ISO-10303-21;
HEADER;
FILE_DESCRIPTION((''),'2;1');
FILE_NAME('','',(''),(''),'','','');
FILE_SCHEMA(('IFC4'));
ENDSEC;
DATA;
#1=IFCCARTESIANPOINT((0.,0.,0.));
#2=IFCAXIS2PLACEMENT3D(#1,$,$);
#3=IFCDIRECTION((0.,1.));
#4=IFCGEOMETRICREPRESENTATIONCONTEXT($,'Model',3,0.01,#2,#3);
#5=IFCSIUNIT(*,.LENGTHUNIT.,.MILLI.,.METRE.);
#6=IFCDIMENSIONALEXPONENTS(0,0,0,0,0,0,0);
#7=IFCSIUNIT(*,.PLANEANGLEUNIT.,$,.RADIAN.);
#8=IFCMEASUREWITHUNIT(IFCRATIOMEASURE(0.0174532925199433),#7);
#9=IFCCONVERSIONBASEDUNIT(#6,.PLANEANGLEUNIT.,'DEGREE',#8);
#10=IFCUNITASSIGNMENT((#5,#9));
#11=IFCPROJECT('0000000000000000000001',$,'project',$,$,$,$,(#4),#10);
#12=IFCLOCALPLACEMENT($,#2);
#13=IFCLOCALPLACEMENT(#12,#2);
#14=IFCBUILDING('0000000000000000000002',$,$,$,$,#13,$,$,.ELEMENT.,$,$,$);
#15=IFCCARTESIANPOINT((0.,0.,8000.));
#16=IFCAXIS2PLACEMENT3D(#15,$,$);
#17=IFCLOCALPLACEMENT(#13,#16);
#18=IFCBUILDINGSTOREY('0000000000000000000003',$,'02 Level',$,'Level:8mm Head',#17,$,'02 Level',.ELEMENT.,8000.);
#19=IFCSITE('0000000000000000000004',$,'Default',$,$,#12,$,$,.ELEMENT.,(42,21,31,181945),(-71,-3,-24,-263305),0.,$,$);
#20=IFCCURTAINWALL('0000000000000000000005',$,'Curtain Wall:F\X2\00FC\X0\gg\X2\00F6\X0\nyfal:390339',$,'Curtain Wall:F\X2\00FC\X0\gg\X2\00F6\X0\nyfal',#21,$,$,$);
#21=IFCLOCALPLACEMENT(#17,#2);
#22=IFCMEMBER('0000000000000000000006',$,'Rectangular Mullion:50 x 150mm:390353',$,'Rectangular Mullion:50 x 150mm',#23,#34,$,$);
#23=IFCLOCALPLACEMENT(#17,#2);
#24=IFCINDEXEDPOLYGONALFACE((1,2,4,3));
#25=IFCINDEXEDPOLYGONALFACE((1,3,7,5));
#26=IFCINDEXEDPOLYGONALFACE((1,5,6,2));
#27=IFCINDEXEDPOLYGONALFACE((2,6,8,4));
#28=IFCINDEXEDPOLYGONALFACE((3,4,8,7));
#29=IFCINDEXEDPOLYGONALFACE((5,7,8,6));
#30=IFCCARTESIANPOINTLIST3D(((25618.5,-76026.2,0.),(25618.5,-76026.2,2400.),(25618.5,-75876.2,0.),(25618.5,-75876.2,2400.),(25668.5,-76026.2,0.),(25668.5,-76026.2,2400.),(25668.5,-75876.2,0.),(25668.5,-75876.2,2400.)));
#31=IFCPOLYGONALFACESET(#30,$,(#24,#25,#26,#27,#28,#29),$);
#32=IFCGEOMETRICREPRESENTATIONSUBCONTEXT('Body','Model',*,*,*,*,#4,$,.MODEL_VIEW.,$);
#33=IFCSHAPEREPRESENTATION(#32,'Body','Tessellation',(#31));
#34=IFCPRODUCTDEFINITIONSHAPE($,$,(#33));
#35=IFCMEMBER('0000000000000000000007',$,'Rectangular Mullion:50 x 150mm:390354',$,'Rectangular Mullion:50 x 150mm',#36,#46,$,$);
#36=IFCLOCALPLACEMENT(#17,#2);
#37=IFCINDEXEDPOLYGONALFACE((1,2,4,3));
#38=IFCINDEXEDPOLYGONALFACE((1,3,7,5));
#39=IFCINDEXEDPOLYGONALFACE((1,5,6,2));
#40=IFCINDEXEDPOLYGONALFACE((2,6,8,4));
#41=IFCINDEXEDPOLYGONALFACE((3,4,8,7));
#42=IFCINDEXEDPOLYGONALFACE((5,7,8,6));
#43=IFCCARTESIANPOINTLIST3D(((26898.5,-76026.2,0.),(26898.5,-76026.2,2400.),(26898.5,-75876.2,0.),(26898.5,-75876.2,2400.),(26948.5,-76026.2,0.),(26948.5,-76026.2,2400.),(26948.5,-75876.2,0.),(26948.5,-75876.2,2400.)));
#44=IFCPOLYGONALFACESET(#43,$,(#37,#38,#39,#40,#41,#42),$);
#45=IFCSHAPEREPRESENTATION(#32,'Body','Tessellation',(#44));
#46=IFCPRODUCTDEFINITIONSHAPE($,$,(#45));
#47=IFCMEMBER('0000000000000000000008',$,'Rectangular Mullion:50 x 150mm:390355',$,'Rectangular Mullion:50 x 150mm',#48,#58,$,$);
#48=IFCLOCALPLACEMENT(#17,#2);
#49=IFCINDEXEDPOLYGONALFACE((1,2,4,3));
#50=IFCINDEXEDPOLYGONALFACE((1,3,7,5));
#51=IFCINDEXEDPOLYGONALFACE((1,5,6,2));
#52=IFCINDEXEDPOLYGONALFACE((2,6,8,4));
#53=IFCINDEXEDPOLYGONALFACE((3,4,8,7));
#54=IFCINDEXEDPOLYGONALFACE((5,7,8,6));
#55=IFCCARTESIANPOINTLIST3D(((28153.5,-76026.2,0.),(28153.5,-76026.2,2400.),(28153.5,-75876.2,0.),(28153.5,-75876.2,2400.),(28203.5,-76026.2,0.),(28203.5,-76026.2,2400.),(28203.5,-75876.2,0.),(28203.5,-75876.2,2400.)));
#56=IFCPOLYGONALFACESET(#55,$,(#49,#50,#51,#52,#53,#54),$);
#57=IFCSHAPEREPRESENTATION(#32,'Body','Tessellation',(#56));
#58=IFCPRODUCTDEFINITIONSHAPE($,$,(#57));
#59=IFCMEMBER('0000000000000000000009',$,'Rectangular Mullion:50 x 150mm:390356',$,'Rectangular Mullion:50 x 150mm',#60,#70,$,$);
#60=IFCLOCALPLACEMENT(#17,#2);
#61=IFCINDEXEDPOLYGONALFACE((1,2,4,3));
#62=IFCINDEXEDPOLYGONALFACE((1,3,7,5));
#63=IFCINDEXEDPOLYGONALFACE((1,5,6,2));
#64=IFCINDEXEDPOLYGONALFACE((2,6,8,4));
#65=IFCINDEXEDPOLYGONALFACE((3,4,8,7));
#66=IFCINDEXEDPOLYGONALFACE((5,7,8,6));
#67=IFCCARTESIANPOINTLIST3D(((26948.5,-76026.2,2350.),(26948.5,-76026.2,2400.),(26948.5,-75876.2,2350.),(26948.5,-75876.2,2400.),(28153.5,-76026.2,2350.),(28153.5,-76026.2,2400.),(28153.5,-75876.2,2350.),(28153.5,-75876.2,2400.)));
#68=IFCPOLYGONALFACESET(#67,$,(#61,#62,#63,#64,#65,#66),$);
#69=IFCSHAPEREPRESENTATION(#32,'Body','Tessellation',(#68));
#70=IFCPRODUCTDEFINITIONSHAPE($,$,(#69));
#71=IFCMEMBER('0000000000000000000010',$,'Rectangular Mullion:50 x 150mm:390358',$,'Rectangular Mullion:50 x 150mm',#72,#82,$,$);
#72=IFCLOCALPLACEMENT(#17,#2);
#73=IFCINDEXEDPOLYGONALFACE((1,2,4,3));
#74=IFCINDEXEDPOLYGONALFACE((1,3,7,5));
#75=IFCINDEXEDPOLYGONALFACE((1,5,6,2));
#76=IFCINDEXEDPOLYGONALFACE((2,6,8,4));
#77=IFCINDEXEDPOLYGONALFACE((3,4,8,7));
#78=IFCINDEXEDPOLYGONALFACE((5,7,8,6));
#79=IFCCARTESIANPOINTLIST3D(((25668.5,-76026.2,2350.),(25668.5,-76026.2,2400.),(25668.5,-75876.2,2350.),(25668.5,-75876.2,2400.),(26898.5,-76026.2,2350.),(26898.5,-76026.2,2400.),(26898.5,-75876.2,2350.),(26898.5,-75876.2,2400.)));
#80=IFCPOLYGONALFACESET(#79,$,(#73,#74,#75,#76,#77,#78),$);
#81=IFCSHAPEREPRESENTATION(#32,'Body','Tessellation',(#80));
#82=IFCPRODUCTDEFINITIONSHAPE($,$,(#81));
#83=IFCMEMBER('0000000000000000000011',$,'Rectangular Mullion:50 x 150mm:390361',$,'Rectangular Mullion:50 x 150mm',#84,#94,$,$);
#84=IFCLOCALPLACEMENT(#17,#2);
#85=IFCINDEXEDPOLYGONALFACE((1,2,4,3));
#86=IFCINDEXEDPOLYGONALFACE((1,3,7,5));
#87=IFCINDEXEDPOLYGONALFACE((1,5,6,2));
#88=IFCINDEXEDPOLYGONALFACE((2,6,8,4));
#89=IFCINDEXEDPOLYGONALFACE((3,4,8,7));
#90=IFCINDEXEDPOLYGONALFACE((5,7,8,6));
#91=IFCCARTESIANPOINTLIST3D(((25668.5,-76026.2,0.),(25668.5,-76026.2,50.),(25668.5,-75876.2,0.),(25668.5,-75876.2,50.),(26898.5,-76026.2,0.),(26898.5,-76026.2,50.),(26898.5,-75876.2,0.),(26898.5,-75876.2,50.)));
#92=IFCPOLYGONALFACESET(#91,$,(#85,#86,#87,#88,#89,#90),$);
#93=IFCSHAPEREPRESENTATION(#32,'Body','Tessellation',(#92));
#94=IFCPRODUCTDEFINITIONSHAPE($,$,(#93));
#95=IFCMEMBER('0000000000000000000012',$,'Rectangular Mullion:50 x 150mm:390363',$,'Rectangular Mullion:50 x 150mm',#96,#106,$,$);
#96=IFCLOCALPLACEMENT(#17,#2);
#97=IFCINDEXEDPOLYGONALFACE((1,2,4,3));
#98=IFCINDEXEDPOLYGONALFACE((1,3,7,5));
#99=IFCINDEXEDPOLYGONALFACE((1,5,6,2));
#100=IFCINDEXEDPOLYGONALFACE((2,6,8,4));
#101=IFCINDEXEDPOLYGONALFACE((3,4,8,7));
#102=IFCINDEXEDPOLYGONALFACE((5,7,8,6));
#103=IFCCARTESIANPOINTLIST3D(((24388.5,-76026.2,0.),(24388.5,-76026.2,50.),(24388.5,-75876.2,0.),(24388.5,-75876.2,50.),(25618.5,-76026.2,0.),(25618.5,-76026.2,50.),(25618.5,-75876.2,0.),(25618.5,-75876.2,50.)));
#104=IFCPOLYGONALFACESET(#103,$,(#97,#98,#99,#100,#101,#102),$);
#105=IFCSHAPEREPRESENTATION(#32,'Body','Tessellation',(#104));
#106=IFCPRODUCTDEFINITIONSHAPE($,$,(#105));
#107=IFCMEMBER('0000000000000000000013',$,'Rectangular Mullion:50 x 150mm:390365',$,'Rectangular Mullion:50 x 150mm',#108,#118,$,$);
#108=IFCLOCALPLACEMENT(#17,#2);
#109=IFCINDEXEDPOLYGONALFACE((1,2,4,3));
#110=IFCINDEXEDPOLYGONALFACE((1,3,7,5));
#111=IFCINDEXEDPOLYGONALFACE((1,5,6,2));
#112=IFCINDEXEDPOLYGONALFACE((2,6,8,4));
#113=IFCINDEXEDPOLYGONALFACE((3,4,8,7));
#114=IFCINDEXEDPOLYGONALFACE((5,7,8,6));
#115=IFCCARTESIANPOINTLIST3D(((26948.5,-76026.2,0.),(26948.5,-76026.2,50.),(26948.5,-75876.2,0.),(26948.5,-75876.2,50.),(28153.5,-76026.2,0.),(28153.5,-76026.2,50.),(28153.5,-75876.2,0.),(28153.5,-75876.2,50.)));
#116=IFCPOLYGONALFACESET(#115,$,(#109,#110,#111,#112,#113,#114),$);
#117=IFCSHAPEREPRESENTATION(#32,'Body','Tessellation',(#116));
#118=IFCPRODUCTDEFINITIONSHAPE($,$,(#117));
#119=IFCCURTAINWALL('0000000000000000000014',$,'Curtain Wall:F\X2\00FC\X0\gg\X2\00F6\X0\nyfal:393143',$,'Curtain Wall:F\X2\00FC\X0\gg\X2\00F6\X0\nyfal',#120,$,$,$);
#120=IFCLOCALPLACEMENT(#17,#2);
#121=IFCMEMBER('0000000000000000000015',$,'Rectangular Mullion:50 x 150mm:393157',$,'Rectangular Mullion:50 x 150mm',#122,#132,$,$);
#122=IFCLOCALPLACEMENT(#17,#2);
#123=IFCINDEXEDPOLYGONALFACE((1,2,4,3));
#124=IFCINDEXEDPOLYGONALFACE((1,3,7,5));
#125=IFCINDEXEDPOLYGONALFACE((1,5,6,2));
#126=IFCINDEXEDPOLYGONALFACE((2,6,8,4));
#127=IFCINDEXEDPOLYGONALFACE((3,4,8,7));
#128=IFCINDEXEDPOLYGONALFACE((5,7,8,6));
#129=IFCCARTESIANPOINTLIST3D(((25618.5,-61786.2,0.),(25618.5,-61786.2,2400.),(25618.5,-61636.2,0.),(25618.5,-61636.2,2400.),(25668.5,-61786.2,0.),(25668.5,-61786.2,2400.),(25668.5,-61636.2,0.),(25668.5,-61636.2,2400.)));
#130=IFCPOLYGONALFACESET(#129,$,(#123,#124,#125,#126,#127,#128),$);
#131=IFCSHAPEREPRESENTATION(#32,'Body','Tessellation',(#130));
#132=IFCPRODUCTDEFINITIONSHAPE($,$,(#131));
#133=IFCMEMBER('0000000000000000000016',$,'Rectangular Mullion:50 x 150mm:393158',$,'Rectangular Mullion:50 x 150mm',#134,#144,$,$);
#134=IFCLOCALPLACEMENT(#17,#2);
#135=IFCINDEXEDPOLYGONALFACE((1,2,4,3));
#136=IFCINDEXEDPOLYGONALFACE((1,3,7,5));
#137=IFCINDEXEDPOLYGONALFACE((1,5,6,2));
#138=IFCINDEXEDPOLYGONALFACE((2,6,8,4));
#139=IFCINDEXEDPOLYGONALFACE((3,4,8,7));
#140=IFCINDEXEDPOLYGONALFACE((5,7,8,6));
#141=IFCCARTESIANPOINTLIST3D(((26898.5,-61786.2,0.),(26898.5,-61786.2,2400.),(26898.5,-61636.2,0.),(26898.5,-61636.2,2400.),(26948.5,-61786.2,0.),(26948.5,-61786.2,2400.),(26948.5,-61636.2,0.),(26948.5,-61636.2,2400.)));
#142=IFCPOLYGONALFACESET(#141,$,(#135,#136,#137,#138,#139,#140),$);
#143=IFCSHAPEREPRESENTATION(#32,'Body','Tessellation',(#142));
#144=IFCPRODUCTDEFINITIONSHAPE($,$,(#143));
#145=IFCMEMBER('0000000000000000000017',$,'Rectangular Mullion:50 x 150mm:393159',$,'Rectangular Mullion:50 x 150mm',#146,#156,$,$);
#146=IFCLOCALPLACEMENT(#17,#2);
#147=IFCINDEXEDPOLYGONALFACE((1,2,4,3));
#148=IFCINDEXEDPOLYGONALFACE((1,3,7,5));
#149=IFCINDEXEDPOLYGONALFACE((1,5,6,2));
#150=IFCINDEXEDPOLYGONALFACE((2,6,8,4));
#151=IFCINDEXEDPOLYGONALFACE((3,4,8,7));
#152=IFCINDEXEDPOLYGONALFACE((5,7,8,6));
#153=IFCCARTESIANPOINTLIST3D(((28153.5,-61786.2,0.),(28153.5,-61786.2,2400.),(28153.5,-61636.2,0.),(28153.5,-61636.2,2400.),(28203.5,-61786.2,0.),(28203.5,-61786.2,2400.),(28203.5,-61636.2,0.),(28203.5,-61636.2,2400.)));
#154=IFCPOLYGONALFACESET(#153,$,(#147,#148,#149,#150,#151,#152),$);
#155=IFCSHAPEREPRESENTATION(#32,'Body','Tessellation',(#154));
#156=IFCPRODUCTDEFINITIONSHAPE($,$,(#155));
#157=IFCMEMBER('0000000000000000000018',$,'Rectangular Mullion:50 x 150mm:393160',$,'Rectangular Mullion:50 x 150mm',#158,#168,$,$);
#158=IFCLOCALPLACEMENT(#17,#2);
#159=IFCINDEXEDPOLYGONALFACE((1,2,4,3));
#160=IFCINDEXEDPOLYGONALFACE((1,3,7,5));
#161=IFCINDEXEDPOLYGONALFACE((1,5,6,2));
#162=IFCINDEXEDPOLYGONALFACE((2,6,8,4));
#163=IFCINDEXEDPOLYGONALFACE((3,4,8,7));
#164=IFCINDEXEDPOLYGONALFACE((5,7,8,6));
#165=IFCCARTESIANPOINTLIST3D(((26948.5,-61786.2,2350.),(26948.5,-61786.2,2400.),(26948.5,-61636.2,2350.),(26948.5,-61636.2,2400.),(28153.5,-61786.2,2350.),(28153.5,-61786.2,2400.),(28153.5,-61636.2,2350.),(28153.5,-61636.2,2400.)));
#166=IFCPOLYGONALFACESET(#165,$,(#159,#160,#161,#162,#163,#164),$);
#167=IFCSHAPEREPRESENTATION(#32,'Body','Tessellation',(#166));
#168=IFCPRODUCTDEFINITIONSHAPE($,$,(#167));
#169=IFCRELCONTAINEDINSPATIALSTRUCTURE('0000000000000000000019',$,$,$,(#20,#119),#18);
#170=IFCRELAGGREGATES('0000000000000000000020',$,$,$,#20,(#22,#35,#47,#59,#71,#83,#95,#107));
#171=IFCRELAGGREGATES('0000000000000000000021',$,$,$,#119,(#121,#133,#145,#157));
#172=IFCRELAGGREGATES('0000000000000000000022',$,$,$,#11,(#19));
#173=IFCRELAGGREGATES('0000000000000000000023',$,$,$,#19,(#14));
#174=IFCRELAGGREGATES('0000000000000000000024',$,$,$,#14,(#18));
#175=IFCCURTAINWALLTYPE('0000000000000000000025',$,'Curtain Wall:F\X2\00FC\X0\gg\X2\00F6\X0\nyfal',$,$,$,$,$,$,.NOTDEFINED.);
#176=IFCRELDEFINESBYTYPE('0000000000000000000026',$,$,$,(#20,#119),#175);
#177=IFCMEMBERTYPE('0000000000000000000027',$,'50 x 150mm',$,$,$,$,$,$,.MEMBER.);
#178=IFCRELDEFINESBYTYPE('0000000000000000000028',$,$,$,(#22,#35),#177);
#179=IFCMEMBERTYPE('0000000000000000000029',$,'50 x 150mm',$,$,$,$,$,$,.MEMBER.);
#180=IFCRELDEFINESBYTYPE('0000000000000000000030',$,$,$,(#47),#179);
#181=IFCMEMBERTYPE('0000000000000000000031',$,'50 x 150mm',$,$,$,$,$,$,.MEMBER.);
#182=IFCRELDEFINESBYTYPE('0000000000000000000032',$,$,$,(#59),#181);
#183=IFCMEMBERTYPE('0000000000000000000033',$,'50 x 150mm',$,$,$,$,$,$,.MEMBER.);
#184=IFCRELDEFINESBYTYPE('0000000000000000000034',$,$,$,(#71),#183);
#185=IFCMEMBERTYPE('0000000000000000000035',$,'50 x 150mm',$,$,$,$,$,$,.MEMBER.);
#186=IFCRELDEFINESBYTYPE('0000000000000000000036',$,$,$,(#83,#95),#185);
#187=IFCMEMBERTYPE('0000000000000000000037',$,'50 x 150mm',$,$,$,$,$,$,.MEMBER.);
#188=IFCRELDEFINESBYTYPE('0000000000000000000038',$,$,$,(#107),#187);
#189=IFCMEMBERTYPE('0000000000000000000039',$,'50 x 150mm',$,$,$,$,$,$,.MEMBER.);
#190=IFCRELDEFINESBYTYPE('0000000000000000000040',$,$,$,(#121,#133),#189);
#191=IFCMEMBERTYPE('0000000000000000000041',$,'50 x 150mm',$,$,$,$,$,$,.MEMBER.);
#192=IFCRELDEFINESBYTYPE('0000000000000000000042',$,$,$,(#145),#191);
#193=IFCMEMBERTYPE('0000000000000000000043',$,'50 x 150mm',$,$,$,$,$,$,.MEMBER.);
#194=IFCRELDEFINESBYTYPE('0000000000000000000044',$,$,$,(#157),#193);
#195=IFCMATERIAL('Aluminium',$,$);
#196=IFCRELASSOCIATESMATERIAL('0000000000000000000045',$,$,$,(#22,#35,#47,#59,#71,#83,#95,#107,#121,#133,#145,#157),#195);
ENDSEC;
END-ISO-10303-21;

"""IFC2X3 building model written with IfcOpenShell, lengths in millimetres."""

from ifc_helpers import new_model, entity, si_unit, converted_unit, direction, frame, origin, origin_2d_with_axis, place, context, subcontext, project, spatial, rectangle, extrude, source, transform, mapped, material, type_object, type_shapes, element, aggregate, save


model = new_model("IFC2X3")

# Units and contexts
model_context = context("Model", 3, precision=0.01, world=origin(), true_north=direction((0.0, 1.0)))
body_context = subcontext(model_context, "Body", "Model", "MODEL_VIEW")
ifc_project = project(units=[si_unit("LENGTHUNIT", "METRE", prefix="MILLI"), converted_unit("PLANEANGLEUNIT", "DEGREE", entity("IfcRatioMeasure", 0.0174532925199433), si_unit("PLANEANGLEUNIT", "RADIAN"), dimensions=[0, 0, 0, 0, 0, 0, 0])], contexts=[model_context])

# Site, building, storey
site_placement = place(None, origin())
site = spatial("IfcSite", under=ifc_project, at=site_placement, Name="Default", CompositionType="ELEMENT", RefLatitude=(42, 21, 31, 181945), RefLongitude=(-71, -3, -24, -263305), RefElevation=0.0)
building_placement = place(site_placement, origin())
building = spatial("IfcBuilding", under=site, at=building_placement, CompositionType="ELEMENT")
storey_placement = place(building_placement, frame((0.0, 0.0, 8000.0)))
storey = spatial("IfcBuildingStorey", under=building, at=storey_placement, Name="02 Level", ObjectType="Level:8mm Head", LongName="02 Level", CompositionType="ELEMENT", Elevation=8000.0)

# Curtain walls, members
curtain_wall_type = type_object("IfcCurtainWallType", Name="Curtain Wall:Függönyfal", PredefinedType="NOTDEFINED")
curtain_wall_1_placement = place(storey_placement, frame((0.0, 0.0, -8000.0)))
curtain_wall_1 = element("IfcCurtainWall", 1, at=curtain_wall_1_placement, inside=storey, type_object=curtain_wall_type, Name="Curtain Wall:Függönyfal:390339", ObjectType="Curtain Wall:Függönyfal")
ifc_material_1 = material(Name="Aluminium")
member_type_1 = type_object("IfcMemberType", Name="50 x 150mm", PredefinedType="MEMBER")
shared_shape_1 = source(origin(), body_context, "Body", "SweptSolid", [
    extrude(rectangle(XDim=150.0, YDim=50.0, at=origin_2d_with_axis()), frame((0.0, 0.0, -2400.0), z_axis=(0.0, 0.0, 1.0), x_axis=(0.0, -1.0, 0.0)), (0.0, 0.0, 1.0), 2400.0),
])
type_shapes(member_type_1, [shared_shape_1])
member_1_placement = place(storey_placement, frame((25643.5, -75951.2, 0.0), z_axis=(0.0, 0.0, -1.0), x_axis=(-1.0, 0.0, 0.0)))
member_1 = element("IfcMember", 2, at=member_1_placement, type_object=member_type_1, material=ifc_material_1, Name="Rectangular Mullion:50 x 150mm:390353", ObjectType="Rectangular Mullion:50 x 150mm", context=body_context, shape_type="MappedRepresentation", body=[
    mapped(shared_shape_1, transform((0.0, 0.0, 0.0), scale=1.0)),
])
member_2_placement = place(storey_placement, frame((26923.5, -75951.2, 0.0), z_axis=(0.0, 0.0, -1.0), x_axis=(-1.0, 0.0, 0.0)))
member_2 = element("IfcMember", 3, at=member_2_placement, type_object=member_type_1, material=ifc_material_1, Name="Rectangular Mullion:50 x 150mm:390354", ObjectType="Rectangular Mullion:50 x 150mm", context=body_context, shape_type="MappedRepresentation", body=[
    mapped(shared_shape_1, transform((0.0, 0.0, 0.0), scale=1.0)),
])
member_type_2 = type_object("IfcMemberType", Name="50 x 150mm", PredefinedType="MEMBER")
shared_shape_2 = source(origin(), body_context, "Body", "SweptSolid", [
    extrude(rectangle(XDim=150.0, YDim=50.0, at=origin_2d_with_axis()), frame((-25.0, 0.0, -2400.0), z_axis=(0.0, 0.0, 1.0), x_axis=(0.0, -1.0, 0.0)), (0.0, 0.0, 1.0), 2400.0),
])
type_shapes(member_type_2, [shared_shape_2])
member_3_placement = place(storey_placement, frame((28203.5, -75951.2, 2400.0)))
member_3 = element("IfcMember", 4, at=member_3_placement, type_object=member_type_2, material=ifc_material_1, Name="Rectangular Mullion:50 x 150mm:390355", ObjectType="Rectangular Mullion:50 x 150mm", context=body_context, shape_type="MappedRepresentation", body=[
    mapped(shared_shape_2, transform((0.0, 0.0, 0.0), scale=1.0)),
])
member_type_3 = type_object("IfcMemberType", Name="50 x 150mm", PredefinedType="MEMBER")
shared_shape_3 = source(origin(), body_context, "Body", "SweptSolid", [
    extrude(rectangle(XDim=150.0, YDim=50.0, at=origin_2d_with_axis()), frame((-25.0, 0.0, -1205.0), z_axis=(0.0, 0.0, 1.0), x_axis=(0.0, -1.0, 0.0)), (0.0, 0.0, 1.0), 1205.0),
])
type_shapes(member_type_3, [shared_shape_3])
member_4_placement = place(storey_placement, frame((26948.5, -75951.2, 2400.0), z_axis=(-1.0, 0.0, 0.0), x_axis=(0.0, 0.0, 1.0)))
member_4 = element("IfcMember", 5, at=member_4_placement, type_object=member_type_3, material=ifc_material_1, Name="Rectangular Mullion:50 x 150mm:390356", ObjectType="Rectangular Mullion:50 x 150mm", context=body_context, shape_type="MappedRepresentation", body=[
    mapped(shared_shape_3, transform((0.0, 0.0, 0.0), scale=1.0)),
])
member_type_4 = type_object("IfcMemberType", Name="50 x 150mm", PredefinedType="MEMBER")
shared_shape_4 = source(origin(), body_context, "Body", "SweptSolid", [
    extrude(rectangle(XDim=150.0, YDim=50.0, at=origin_2d_with_axis()), frame((-25.0, 0.0, -1230.0), z_axis=(0.0, 0.0, 1.0), x_axis=(0.0, -1.0, 0.0)), (0.0, 0.0, 1.0), 1230.0),
])
type_shapes(member_type_4, [shared_shape_4])
member_5_placement = place(storey_placement, frame((25668.5, -75951.2, 2400.0), z_axis=(-1.0, 0.0, 0.0), x_axis=(0.0, 0.0, 1.0)))
member_5 = element("IfcMember", 6, at=member_5_placement, type_object=member_type_4, material=ifc_material_1, Name="Rectangular Mullion:50 x 150mm:390358", ObjectType="Rectangular Mullion:50 x 150mm", context=body_context, shape_type="MappedRepresentation", body=[
    mapped(shared_shape_4, transform((0.0, 0.0, 0.0), scale=1.0)),
])
member_type_5 = type_object("IfcMemberType", Name="50 x 150mm", PredefinedType="MEMBER")
shared_shape_5 = source(origin(), body_context, "Body", "SweptSolid", [
    extrude(rectangle(XDim=150.0, YDim=50.0, at=origin_2d_with_axis()), frame((-25.0, 0.0, -1230.0), z_axis=(0.0, 0.0, 1.0), x_axis=(0.0, -1.0, 0.0)), (0.0, 0.0, 1.0), 1230.0),
])
type_shapes(member_type_5, [shared_shape_5])
member_6_placement = place(storey_placement, frame((26898.5, -75951.2, 0.0), z_axis=(1.0, 0.0, 0.0), x_axis=(0.0, 0.0, -1.0)))
member_6 = element("IfcMember", 7, at=member_6_placement, type_object=member_type_5, material=ifc_material_1, Name="Rectangular Mullion:50 x 150mm:390361", ObjectType="Rectangular Mullion:50 x 150mm", context=body_context, shape_type="MappedRepresentation", body=[
    mapped(shared_shape_5, transform((0.0, 0.0, 0.0), scale=1.0)),
])
member_7_placement = place(storey_placement, frame((25618.5, -75951.2, 0.0), z_axis=(1.0, 0.0, 0.0), x_axis=(0.0, 0.0, -1.0)))
member_7 = element("IfcMember", 8, at=member_7_placement, type_object=member_type_5, material=ifc_material_1, Name="Rectangular Mullion:50 x 150mm:390363", ObjectType="Rectangular Mullion:50 x 150mm", context=body_context, shape_type="MappedRepresentation", body=[
    mapped(shared_shape_5, transform((0.0, 0.0, 0.0), scale=1.0)),
])
member_type_6 = type_object("IfcMemberType", Name="50 x 150mm", PredefinedType="MEMBER")
shared_shape_6 = source(origin(), body_context, "Body", "SweptSolid", [
    extrude(rectangle(XDim=150.0, YDim=50.0, at=origin_2d_with_axis()), frame((-25.0, 0.0, -1205.0), z_axis=(0.0, 0.0, 1.0), x_axis=(0.0, -1.0, 0.0)), (0.0, 0.0, 1.0), 1205.0),
])
type_shapes(member_type_6, [shared_shape_6])
member_8_placement = place(storey_placement, frame((28153.5, -75951.2, 0.0), z_axis=(1.0, 0.0, 0.0), x_axis=(0.0, 0.0, -1.0)))
member_8 = element("IfcMember", 9, at=member_8_placement, type_object=member_type_6, material=ifc_material_1, Name="Rectangular Mullion:50 x 150mm:390365", ObjectType="Rectangular Mullion:50 x 150mm", context=body_context, shape_type="MappedRepresentation", body=[
    mapped(shared_shape_6, transform((0.0, 0.0, 0.0), scale=1.0)),
])
curtain_wall_2_placement = place(storey_placement, frame((0.0, 0.0, -8000.0)))
curtain_wall_2 = element("IfcCurtainWall", 10, at=curtain_wall_2_placement, inside=storey, type_object=curtain_wall_type, Name="Curtain Wall:Függönyfal:393143", ObjectType="Curtain Wall:Függönyfal")
member_type_7 = type_object("IfcMemberType", Name="50 x 150mm", PredefinedType="MEMBER")
shared_shape_7 = source(origin(), body_context, "Body", "SweptSolid", [
    extrude(rectangle(XDim=150.0, YDim=50.0, at=origin_2d_with_axis()), frame((0.0, 0.0, -2400.0), z_axis=(0.0, 0.0, 1.0), x_axis=(0.0, -1.0, 0.0)), (0.0, 0.0, 1.0), 2400.0),
])
type_shapes(member_type_7, [shared_shape_7])
member_9_placement = place(storey_placement, frame((25643.5, -61711.2, 0.0), z_axis=(0.0, 0.0, -1.0), x_axis=(-1.0, 0.0, 0.0)))
member_9 = element("IfcMember", 11, at=member_9_placement, type_object=member_type_7, material=ifc_material_1, Name="Rectangular Mullion:50 x 150mm:393157", ObjectType="Rectangular Mullion:50 x 150mm", context=body_context, shape_type="MappedRepresentation", body=[
    mapped(shared_shape_7, transform((0.0, 0.0, 0.0), scale=1.0)),
])
member_10_placement = place(storey_placement, frame((26923.5, -61711.2, 0.0), z_axis=(0.0, 0.0, -1.0), x_axis=(-1.0, 0.0, 0.0)))
member_10 = element("IfcMember", 12, at=member_10_placement, type_object=member_type_7, material=ifc_material_1, Name="Rectangular Mullion:50 x 150mm:393158", ObjectType="Rectangular Mullion:50 x 150mm", context=body_context, shape_type="MappedRepresentation", body=[
    mapped(shared_shape_7, transform((0.0, 0.0, 0.0), scale=1.0)),
])
member_type_8 = type_object("IfcMemberType", Name="50 x 150mm", PredefinedType="MEMBER")
shared_shape_8 = source(origin(), body_context, "Body", "SweptSolid", [
    extrude(rectangle(XDim=150.0, YDim=50.0, at=origin_2d_with_axis()), frame((-25.0, 0.0, -2400.0), z_axis=(0.0, 0.0, 1.0), x_axis=(0.0, -1.0, 0.0)), (0.0, 0.0, 1.0), 2400.0),
])
type_shapes(member_type_8, [shared_shape_8])
member_11_placement = place(storey_placement, frame((28203.5, -61711.2, 2400.0)))
member_11 = element("IfcMember", 13, at=member_11_placement, type_object=member_type_8, material=ifc_material_1, Name="Rectangular Mullion:50 x 150mm:393159", ObjectType="Rectangular Mullion:50 x 150mm", context=body_context, shape_type="MappedRepresentation", body=[
    mapped(shared_shape_8, transform((0.0, 0.0, 0.0), scale=1.0)),
])
member_type_9 = type_object("IfcMemberType", Name="50 x 150mm", PredefinedType="MEMBER")
shared_shape_9 = source(origin(), body_context, "Body", "SweptSolid", [
    extrude(rectangle(XDim=150.0, YDim=50.0, at=origin_2d_with_axis()), frame((-25.0, 0.0, -1205.0), z_axis=(0.0, 0.0, 1.0), x_axis=(0.0, -1.0, 0.0)), (0.0, 0.0, 1.0), 1205.0),
])
type_shapes(member_type_9, [shared_shape_9])
member_12_placement = place(storey_placement, frame((26948.5, -61711.2, 2400.0), z_axis=(-1.0, 0.0, 0.0), x_axis=(0.0, 0.0, 1.0)))
member_12 = element("IfcMember", 14, at=member_12_placement, type_object=member_type_9, material=ifc_material_1, Name="Rectangular Mullion:50 x 150mm:393160", ObjectType="Rectangular Mullion:50 x 150mm", context=body_context, shape_type="MappedRepresentation", body=[
    mapped(shared_shape_9, transform((0.0, 0.0, 0.0), scale=1.0)),
])

aggregate(curtain_wall_1, [member_1, member_2, member_3, member_4, member_5, member_6, member_7, member_8])
aggregate(curtain_wall_2, [member_9, member_10, member_11, member_12])

save(model, "model.ifc")
